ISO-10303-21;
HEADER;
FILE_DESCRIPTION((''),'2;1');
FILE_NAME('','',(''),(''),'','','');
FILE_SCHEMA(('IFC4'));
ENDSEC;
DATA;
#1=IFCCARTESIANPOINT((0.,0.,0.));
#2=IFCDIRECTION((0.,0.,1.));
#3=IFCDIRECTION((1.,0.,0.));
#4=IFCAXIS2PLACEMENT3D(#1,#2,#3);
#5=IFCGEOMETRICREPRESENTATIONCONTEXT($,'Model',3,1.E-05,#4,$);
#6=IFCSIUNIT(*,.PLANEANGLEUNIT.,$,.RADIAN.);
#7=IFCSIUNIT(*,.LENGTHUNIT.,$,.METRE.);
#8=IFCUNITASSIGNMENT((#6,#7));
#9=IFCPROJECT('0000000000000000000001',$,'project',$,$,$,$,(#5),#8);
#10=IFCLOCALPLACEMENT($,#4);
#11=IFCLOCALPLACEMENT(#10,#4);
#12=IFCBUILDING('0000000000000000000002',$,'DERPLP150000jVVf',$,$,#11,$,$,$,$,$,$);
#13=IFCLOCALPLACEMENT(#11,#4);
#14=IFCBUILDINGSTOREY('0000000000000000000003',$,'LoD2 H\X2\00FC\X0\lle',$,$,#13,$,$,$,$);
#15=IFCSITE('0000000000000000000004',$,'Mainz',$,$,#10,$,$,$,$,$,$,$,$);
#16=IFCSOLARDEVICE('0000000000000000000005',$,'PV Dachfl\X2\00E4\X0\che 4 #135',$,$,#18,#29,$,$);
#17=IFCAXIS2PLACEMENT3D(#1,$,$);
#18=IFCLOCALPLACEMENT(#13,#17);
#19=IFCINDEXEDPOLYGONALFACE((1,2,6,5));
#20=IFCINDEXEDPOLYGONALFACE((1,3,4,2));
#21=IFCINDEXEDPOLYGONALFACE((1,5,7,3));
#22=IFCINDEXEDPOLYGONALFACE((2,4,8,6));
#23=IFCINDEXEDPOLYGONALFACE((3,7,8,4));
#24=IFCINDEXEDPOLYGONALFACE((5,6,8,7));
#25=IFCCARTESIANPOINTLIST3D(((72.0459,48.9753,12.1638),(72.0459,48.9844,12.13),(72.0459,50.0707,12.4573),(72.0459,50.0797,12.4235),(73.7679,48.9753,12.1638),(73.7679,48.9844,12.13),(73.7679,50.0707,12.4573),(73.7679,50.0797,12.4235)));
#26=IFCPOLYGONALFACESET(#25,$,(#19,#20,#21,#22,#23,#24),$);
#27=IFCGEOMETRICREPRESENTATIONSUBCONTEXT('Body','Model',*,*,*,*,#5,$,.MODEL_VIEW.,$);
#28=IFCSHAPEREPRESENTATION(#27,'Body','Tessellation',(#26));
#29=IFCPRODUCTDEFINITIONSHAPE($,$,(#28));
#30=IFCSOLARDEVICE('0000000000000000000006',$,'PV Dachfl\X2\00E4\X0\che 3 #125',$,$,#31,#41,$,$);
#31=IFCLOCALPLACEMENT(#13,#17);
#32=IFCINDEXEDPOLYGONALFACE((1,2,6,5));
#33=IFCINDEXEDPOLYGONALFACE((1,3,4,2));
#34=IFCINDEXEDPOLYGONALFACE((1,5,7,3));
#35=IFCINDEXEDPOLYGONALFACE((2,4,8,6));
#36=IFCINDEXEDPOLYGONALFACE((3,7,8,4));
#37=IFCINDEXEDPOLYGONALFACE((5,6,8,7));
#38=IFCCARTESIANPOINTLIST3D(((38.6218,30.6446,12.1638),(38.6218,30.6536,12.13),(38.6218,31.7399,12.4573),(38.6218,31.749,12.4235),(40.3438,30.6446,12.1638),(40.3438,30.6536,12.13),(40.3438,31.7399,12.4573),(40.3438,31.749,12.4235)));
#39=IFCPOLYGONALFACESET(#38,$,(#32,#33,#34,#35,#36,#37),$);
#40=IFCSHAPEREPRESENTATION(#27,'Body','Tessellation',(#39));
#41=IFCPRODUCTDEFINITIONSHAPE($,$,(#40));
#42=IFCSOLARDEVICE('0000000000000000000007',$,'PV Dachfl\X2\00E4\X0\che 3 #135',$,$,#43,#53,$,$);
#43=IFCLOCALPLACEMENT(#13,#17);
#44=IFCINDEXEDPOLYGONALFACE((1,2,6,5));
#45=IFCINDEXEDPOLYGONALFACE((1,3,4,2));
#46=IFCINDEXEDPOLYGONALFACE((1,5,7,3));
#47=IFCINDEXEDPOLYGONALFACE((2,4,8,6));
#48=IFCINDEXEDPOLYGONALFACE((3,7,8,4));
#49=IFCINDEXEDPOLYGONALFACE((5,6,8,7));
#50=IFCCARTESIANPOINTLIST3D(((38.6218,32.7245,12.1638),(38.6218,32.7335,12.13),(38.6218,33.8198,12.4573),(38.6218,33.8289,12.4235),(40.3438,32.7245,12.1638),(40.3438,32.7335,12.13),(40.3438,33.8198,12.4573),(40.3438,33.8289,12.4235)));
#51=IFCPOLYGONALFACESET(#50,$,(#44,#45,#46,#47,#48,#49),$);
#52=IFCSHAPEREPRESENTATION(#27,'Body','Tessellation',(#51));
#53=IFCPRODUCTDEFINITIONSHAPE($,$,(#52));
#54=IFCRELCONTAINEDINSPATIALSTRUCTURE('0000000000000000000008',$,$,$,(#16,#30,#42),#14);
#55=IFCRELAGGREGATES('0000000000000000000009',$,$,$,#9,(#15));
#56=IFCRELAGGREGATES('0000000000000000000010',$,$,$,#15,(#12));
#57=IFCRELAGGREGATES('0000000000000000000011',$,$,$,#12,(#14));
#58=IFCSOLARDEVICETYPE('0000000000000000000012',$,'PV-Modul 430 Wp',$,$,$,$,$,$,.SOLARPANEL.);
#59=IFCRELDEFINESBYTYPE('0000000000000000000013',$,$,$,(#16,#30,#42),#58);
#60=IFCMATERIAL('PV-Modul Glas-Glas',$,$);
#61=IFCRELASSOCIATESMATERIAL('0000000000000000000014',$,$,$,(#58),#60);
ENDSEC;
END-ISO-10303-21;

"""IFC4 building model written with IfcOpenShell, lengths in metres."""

from ifc_helpers import new_model, si_unit, frame, frame_2d, origin, origin_with_axes, place, context, subcontext, project, spatial, rectangle, extrude, source, transform, mapped, material, type_object, type_shapes, element, save


model = new_model("IFC4")

# Units and contexts
model_context = context("Model", 3, precision=1e-05, world=origin_with_axes())
body_context = subcontext(model_context, "Body", "Model", "MODEL_VIEW")
ifc_project = project(units=[si_unit("PLANEANGLEUNIT", "RADIAN"), si_unit("LENGTHUNIT", "METRE")], contexts=[model_context])

# Site, building, storey
site_placement = place(None, origin_with_axes())
site = spatial("IfcSite", under=ifc_project, at=site_placement, Name="Mainz")
building_placement = place(site_placement, origin_with_axes())
building = spatial("IfcBuilding", under=site, at=building_placement, Name="DERPLP150000jVVf")
storey_placement = place(building_placement, origin_with_axes())
storey = spatial("IfcBuildingStorey", under=building, at=storey_placement, Name="LoD2 Hülle")

# Solar devices
ifc_material = material(Name="PV-Modul Glas-Glas")
solar_device_type = type_object("IfcSolarDeviceType", Name="PV-Modul 430 Wp", PredefinedType="SOLARPANEL", material=ifc_material)
shared_shape = source(origin_with_axes(), body_context, "Body", "SweptSolid", [
    extrude(rectangle(XDim=1.722, YDim=1.134, at=frame_2d((0.861, 0.567))), origin(), (0.0, 0.0, 1.0), 0.035),
])
type_shapes(solar_device_type, [shared_shape])
for number, where, z_axis, x_axis, name in (
    (1, (72.0459, 48.9844, 12.13), (0.0, -0.258819, 0.965926), (1.0, 0.0, 0.0), "PV Dachfläche 4 #135"),
    (2, (38.6218, 30.6536, 12.13), (0.0, -0.258819, 0.965926), (1.0, 0.0, 0.0), "PV Dachfläche 3 #125"),
    (3, (38.6218, 32.7335, 12.13), (0.0, -0.258819, 0.965926), (1.0, 0.0, 0.0), "PV Dachfläche 3 #135"),
):
    element("IfcSolarDevice", number, at=place(storey_placement, frame(where, z_axis=z_axis, x_axis=x_axis)), inside=storey, type_object=solar_device_type, Name=name, context=body_context, shape_type="MappedRepresentation", body=[
        mapped(shared_shape, transform((0.0, 0.0, 0.0), x_axis=(1.0, 0.0, 0.0), y_axis=(0.0, 1.0, 0.0), z_axis=(0.0, 0.0, 1.0), scale=1.0)),
    ])

save(model, "model.ifc")
